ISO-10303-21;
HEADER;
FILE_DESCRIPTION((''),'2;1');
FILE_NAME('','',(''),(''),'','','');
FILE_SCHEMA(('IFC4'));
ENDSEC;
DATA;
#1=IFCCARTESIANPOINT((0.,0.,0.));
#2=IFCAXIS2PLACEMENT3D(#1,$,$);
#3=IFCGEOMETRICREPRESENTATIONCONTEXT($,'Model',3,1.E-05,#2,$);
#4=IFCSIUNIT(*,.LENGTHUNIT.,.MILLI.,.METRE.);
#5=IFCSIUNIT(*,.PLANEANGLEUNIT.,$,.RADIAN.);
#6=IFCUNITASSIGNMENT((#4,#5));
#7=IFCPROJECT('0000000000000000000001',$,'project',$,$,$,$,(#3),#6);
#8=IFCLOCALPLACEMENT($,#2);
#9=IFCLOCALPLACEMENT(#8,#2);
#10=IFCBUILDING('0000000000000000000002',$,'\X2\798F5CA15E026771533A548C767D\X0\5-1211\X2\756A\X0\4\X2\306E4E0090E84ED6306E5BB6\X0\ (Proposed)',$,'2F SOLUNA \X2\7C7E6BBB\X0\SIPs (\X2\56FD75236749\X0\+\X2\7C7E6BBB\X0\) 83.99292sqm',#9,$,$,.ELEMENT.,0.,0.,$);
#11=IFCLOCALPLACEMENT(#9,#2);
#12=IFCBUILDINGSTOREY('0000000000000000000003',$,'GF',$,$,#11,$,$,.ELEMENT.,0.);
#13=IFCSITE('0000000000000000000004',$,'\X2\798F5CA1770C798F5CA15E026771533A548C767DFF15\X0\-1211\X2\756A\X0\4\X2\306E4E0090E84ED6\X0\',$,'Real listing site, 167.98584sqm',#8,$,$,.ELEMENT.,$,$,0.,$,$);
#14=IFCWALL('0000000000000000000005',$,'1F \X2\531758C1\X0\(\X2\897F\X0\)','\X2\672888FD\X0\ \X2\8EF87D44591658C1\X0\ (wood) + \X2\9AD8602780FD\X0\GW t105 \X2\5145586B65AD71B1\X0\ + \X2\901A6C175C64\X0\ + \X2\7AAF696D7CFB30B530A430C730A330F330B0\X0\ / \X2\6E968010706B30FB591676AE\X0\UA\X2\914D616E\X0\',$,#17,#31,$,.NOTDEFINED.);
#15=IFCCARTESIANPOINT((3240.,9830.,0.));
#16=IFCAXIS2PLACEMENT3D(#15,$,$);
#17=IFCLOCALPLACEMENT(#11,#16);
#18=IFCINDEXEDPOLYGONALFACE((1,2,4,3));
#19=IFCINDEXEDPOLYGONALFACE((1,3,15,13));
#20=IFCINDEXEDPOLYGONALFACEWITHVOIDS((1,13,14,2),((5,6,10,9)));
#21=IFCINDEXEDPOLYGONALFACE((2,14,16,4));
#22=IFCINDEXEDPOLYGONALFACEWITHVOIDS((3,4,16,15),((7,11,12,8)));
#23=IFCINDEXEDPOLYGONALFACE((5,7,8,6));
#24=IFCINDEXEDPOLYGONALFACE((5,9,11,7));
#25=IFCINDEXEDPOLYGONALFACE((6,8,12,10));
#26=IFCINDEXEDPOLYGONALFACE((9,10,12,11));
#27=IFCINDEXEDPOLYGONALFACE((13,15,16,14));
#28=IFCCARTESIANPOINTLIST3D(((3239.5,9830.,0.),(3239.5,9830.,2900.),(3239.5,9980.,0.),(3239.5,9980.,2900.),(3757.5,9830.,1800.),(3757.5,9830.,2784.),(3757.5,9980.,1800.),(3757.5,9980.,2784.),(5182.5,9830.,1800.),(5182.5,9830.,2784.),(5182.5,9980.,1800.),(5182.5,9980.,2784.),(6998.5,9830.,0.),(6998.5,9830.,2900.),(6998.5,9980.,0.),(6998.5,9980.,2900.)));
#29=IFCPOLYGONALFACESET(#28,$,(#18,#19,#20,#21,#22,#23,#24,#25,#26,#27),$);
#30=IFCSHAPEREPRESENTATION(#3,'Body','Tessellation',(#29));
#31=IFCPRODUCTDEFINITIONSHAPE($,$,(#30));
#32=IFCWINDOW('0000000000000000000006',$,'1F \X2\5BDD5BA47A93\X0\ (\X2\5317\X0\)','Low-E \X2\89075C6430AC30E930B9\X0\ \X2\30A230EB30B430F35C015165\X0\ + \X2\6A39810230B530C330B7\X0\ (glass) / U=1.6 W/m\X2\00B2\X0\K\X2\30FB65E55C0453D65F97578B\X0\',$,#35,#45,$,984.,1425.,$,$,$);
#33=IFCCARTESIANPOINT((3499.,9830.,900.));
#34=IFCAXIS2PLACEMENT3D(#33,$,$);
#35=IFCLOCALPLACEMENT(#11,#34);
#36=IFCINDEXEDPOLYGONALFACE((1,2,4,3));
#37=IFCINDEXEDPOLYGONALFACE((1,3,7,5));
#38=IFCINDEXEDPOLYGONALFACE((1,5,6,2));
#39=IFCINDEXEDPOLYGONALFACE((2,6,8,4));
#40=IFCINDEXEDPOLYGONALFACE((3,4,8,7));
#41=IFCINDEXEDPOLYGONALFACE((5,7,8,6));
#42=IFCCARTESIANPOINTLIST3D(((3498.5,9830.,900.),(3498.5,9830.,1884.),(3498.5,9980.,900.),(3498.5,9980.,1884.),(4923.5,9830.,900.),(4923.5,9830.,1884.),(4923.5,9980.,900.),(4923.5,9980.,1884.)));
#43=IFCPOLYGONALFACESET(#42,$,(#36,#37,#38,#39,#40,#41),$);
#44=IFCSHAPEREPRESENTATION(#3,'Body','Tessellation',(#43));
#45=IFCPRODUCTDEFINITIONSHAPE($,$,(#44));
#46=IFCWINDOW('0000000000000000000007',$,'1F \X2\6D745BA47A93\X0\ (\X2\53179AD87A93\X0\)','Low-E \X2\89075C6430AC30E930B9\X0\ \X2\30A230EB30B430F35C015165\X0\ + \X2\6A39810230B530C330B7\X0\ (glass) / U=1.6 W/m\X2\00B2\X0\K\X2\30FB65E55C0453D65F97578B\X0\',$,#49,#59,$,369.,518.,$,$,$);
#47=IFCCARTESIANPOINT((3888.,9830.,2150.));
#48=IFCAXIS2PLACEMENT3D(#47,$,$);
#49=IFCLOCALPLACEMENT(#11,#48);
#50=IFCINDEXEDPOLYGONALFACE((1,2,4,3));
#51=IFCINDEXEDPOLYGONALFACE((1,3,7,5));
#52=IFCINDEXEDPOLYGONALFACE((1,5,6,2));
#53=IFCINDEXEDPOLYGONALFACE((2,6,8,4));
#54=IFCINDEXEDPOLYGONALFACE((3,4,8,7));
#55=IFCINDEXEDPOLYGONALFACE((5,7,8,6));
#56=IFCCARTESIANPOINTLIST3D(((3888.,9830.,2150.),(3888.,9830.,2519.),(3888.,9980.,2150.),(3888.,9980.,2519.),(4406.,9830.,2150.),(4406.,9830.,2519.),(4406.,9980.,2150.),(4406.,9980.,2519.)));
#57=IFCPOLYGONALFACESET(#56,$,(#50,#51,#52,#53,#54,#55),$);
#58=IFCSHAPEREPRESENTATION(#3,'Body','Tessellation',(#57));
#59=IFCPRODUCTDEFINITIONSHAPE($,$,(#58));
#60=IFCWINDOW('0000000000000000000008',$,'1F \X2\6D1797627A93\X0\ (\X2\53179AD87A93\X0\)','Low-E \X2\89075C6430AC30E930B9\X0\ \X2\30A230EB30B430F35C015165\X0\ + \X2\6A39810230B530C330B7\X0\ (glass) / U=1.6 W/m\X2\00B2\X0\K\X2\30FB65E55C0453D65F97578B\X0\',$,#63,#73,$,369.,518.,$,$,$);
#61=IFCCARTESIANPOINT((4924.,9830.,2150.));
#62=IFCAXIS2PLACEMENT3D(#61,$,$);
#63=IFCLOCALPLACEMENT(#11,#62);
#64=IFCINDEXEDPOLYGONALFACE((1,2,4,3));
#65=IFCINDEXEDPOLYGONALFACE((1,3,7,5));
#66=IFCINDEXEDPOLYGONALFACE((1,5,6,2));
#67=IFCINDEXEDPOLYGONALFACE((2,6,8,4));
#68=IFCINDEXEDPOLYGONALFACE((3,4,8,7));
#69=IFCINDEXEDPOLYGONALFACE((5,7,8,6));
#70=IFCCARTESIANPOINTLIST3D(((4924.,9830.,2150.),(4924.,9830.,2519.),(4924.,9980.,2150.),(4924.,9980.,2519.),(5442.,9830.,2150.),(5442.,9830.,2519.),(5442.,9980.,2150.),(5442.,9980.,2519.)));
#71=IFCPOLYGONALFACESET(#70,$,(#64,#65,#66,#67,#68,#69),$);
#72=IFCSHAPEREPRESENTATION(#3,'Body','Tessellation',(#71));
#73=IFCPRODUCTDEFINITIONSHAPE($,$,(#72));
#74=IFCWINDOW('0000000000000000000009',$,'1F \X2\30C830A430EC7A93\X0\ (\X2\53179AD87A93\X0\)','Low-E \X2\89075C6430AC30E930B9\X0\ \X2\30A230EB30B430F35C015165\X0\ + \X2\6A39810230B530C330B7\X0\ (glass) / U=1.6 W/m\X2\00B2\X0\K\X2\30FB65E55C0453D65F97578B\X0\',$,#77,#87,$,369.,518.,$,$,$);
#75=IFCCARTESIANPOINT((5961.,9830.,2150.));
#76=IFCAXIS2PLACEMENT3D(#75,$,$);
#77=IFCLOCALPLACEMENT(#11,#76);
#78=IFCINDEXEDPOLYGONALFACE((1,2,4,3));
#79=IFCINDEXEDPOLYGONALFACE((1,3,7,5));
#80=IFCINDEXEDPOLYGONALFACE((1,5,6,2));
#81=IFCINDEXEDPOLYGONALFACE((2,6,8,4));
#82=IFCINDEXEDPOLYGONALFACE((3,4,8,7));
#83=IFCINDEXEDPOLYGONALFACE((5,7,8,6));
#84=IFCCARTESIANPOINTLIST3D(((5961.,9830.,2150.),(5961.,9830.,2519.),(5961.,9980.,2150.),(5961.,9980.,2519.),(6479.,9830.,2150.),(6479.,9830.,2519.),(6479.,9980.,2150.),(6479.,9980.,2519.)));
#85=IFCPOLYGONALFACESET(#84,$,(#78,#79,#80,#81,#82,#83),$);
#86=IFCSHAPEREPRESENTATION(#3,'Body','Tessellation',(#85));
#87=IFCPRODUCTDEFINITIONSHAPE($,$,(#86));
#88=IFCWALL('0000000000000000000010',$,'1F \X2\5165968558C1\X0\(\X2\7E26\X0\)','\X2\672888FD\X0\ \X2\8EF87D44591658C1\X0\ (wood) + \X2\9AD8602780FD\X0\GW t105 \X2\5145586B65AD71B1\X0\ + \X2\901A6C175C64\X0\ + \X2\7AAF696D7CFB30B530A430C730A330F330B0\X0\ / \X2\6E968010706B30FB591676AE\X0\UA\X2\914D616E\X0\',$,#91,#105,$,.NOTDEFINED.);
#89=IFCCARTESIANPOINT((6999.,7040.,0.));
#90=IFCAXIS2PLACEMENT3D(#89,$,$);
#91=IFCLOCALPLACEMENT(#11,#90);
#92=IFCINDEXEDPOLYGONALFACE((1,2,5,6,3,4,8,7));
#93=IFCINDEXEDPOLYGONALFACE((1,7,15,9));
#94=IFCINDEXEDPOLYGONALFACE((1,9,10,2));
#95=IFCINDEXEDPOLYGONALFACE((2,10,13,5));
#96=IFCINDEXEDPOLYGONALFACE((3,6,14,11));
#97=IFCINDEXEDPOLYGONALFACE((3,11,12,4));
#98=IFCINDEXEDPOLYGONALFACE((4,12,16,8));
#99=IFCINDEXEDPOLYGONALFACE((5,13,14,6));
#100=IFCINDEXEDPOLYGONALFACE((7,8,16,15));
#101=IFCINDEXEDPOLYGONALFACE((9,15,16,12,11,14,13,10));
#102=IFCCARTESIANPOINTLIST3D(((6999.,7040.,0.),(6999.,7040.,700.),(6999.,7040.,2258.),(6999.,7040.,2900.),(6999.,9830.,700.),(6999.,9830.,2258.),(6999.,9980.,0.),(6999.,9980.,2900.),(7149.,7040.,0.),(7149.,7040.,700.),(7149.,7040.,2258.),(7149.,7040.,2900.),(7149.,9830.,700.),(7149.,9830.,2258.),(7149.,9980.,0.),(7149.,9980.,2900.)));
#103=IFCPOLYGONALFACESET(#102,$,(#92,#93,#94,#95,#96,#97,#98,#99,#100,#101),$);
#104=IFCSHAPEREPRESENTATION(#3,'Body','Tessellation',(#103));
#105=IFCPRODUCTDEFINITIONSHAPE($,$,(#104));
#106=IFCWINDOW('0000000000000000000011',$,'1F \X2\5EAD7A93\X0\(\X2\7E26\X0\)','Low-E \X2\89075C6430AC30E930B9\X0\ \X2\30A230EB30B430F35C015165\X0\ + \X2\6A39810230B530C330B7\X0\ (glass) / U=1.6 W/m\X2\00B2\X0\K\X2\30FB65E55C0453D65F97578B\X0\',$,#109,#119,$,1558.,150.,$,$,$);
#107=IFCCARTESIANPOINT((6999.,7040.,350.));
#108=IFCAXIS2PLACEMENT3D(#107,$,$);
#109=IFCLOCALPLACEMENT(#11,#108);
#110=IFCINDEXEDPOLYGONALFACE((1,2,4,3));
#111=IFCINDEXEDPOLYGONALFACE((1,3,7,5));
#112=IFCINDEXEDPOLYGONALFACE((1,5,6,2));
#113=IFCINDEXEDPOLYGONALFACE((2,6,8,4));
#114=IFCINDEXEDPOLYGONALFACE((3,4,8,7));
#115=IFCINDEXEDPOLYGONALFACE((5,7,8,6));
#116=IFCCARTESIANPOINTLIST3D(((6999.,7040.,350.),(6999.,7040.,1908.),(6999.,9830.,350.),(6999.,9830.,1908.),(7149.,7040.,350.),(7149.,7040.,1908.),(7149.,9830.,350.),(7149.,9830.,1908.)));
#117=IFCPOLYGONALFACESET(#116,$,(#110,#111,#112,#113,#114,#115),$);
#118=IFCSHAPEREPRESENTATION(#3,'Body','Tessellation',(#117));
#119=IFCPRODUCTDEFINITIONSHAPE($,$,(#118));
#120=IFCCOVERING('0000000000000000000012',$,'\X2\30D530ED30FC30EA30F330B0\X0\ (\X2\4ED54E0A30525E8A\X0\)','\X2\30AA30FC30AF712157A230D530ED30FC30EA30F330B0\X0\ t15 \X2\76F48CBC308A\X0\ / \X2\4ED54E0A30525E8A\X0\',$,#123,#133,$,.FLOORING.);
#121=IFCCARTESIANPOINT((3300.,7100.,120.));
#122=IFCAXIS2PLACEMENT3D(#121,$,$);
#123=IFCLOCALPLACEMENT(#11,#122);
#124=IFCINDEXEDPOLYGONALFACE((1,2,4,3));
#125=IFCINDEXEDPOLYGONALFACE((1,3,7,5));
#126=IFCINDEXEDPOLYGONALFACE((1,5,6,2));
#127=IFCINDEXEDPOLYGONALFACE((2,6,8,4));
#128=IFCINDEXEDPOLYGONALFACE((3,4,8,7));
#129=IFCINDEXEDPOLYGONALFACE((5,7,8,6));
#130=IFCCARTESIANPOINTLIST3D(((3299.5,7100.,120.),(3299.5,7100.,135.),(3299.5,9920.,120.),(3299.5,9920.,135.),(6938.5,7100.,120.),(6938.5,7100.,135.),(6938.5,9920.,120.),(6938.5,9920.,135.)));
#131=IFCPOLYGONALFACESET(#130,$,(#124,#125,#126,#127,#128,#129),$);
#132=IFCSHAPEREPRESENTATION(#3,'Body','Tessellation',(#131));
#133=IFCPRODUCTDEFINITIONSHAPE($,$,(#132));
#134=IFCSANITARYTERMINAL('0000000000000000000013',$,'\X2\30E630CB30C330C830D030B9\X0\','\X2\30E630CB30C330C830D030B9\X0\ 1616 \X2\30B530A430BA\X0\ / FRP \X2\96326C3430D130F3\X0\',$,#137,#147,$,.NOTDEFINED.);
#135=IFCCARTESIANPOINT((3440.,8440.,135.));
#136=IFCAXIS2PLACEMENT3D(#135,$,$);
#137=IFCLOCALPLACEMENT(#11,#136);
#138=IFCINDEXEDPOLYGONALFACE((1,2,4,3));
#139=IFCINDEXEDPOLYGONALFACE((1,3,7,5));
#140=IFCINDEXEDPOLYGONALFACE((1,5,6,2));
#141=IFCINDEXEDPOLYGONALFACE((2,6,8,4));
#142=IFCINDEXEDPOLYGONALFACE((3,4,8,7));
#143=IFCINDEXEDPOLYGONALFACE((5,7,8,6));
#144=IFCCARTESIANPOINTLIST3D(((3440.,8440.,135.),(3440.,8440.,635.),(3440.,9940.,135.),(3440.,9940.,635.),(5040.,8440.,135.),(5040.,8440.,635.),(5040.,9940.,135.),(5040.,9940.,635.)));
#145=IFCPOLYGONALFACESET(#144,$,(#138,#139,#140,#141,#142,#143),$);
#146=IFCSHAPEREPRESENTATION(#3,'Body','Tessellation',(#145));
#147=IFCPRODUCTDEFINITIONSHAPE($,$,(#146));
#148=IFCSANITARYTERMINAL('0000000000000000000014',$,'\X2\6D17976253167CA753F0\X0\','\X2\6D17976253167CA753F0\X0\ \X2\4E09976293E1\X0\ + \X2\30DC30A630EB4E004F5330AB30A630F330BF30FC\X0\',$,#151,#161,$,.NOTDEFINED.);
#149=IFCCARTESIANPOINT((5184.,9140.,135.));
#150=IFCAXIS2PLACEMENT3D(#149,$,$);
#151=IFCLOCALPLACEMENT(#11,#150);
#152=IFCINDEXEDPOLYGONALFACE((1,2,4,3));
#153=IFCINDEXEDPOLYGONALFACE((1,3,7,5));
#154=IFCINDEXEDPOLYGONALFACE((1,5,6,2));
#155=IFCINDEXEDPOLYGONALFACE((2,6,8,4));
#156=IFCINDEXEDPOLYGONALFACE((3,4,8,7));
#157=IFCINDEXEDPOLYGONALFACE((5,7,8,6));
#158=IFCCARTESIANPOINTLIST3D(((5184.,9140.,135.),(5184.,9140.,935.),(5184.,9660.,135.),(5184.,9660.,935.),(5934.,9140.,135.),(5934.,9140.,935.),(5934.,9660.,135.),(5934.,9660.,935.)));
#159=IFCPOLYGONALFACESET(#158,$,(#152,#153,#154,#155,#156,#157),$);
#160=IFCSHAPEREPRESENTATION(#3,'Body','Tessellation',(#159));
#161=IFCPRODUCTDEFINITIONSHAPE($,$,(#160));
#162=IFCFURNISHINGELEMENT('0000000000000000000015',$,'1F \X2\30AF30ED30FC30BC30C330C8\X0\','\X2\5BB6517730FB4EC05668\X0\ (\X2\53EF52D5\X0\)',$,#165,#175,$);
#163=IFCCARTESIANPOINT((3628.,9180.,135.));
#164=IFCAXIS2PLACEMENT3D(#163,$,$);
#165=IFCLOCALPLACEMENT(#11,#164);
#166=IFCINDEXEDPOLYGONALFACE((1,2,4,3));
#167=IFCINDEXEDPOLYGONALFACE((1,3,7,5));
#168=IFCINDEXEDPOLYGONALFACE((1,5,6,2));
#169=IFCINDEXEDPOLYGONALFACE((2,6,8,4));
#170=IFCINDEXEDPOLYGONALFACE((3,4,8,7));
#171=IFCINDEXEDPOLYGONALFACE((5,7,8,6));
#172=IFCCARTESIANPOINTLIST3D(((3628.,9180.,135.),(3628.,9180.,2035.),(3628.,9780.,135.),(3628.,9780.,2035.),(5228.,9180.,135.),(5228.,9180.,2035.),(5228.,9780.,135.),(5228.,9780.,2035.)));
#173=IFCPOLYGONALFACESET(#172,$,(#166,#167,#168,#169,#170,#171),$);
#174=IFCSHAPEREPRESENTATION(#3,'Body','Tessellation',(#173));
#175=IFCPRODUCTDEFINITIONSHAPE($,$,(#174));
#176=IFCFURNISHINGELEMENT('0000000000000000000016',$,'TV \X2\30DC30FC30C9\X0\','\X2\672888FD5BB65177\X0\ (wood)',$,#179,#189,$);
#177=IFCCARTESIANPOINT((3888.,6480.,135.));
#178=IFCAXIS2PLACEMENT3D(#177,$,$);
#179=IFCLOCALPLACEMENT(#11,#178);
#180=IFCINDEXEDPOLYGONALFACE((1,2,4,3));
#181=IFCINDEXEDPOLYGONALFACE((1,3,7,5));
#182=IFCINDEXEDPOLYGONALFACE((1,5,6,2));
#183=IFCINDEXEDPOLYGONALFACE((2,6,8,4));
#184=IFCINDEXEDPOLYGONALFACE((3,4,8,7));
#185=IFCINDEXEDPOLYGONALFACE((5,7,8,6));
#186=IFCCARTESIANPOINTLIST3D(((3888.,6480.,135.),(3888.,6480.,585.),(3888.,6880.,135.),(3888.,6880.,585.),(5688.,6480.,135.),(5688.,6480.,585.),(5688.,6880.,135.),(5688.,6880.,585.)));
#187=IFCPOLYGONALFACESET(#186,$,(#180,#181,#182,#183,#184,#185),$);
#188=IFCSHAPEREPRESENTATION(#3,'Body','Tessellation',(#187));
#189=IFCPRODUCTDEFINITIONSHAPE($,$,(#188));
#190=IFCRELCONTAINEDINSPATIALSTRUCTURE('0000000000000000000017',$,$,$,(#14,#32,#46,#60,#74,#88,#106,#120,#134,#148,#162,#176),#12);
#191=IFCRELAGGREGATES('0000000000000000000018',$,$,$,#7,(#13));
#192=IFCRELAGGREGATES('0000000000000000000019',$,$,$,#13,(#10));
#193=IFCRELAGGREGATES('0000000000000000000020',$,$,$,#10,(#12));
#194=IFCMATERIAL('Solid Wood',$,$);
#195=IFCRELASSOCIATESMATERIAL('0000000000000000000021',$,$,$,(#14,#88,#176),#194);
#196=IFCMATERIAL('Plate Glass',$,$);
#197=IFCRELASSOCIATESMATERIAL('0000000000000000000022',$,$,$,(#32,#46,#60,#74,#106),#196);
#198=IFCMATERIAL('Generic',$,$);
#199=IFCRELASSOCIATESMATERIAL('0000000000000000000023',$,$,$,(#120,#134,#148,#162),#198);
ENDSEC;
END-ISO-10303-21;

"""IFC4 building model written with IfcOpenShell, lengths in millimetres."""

from ifc_helpers import new_model, si_unit, frame, frame_2d, origin, place, context, project, spatial, rectangle, extrude, material, element, fill, save


model = new_model("IFC4")

# Units and contexts
model_context = context("Model", 3, precision=1e-05, world=origin())
ifc_project = project(units=[si_unit("LENGTHUNIT", "METRE", prefix="MILLI"), si_unit("PLANEANGLEUNIT", "RADIAN")], contexts=[model_context])

# Site, building, storey
site_placement = place(None, origin())
site = spatial("IfcSite", under=ifc_project, at=site_placement, Name="福岡県福岡市東区和白５-1211番4の一部他", ObjectType="Real listing site, 167.98584sqm", CompositionType="ELEMENT", RefElevation=0.0)
building_placement = place(site_placement, origin())
building = spatial("IfcBuilding", under=site, at=building_placement, Name="福岡市東区和白5-1211番4の一部他の家 (Proposed)", ObjectType="2F SOLUNA 籾殻SIPs (国産杉+籾殻) 83.99292sqm", CompositionType="ELEMENT", ElevationOfRefHeight=0.0, ElevationOfTerrain=0.0)
storey_placement = place(building_placement, origin())
storey = spatial("IfcBuildingStorey", under=building, at=storey_placement, Name="GF", CompositionType="ELEMENT", Elevation=0.0)

# Shared definitions
ifc_material_1 = material(Name="Solid Wood")

# Wall, openings, windows
wall_1_placement = place(storey_placement, frame((3240.0, 9830.0, 0.0)))
wall_1 = element("IfcWall", 1, at=wall_1_placement, inside=storey, material=ifc_material_1, Name="1F 北壁(西)", Description="木製 軸組外壁 (wood) + 高性能GW t105 充填断熱 + 通気層 + 窯業系サイディング / 準耐火・外皮UA配慮", PredefinedType="NOTDEFINED", context=model_context, shape_type="SweptSolid", body=[
    extrude(rectangle(XDim=3759.0, YDim=150.0, at=frame_2d((1879.0, 75.0))), frame((3240.0, 9830.0, 0.0)), (0.0, 0.0, 1.0), 2900.0),
])
opening_1_placement = place(storey_placement, frame((3499.0, 9830.0, 900.0)))
opening_1 = element("IfcOpeningElement", 2, at=opening_1_placement, cuts=wall_1, PredefinedType="NOTDEFINED", context=model_context, shape_type="SweptSolid", body=[
    extrude(rectangle(XDim=1425.0, YDim=150.0, at=frame_2d((712.0, 75.0))), frame((3499.0, 9830.0, 900.0)), (0.0, 0.0, 1.0), 984.0),
])
opening_2_placement = place(storey_placement, frame((3888.0, 9830.0, 2150.0)))
opening_2 = element("IfcOpeningElement", 3, at=opening_2_placement, cuts=wall_1, PredefinedType="NOTDEFINED", context=model_context, shape_type="SweptSolid", body=[
    extrude(rectangle(XDim=518.0, YDim=150.0, at=frame_2d((259.0, 75.0))), frame((3888.0, 9830.0, 2150.0)), (0.0, 0.0, 1.0), 369.0),
])
opening_3_placement = place(storey_placement, frame((4924.0, 9830.0, 2150.0)))
opening_3 = element("IfcOpeningElement", 4, at=opening_3_placement, cuts=wall_1, PredefinedType="NOTDEFINED", context=model_context, shape_type="SweptSolid", body=[
    extrude(rectangle(XDim=518.0, YDim=150.0, at=frame_2d((259.0, 75.0))), frame((4924.0, 9830.0, 2150.0)), (0.0, 0.0, 1.0), 369.0),
])
opening_4_placement = place(storey_placement, frame((5961.0, 9830.0, 2150.0)))
opening_4 = element("IfcOpeningElement", 5, at=opening_4_placement, cuts=wall_1, PredefinedType="NOTDEFINED", context=model_context, shape_type="SweptSolid", body=[
    extrude(rectangle(XDim=518.0, YDim=150.0, at=frame_2d((259.0, 75.0))), frame((5961.0, 9830.0, 2150.0)), (0.0, 0.0, 1.0), 369.0),
])
ifc_material_2 = material(Name="Plate Glass")
window_1_placement = place(storey_placement, frame((3499.0, 9830.0, 900.0)))
window_1 = element("IfcWindow", 6, at=window_1_placement, inside=storey, material=ifc_material_2, Name="1F 寝室窓 (北)", Description="Low-E 複層ガラス アルゴン封入 + 樹脂サッシ (glass) / U=1.6 W/m²K・日射取得型", OverallHeight=984.0, OverallWidth=1425.0, context=model_context, shape_type="SweptSolid", body=[
    extrude(rectangle(XDim=1425.0, YDim=150.0, at=frame_2d((712.0, 75.0))), frame((3499.0, 9830.0, 900.0)), (0.0, 0.0, 1.0), 984.0),
])
fill(opening_1, window_1)
window_2_placement = place(storey_placement, frame((3888.0, 9830.0, 2150.0)))
window_2 = element("IfcWindow", 7, at=window_2_placement, inside=storey, material=ifc_material_2, Name="1F 浴室窓 (北高窓)", Description="Low-E 複層ガラス アルゴン封入 + 樹脂サッシ (glass) / U=1.6 W/m²K・日射取得型", OverallHeight=369.0, OverallWidth=518.0, context=model_context, shape_type="SweptSolid", body=[
    extrude(rectangle(XDim=518.0, YDim=150.0, at=frame_2d((259.0, 75.0))), frame((3888.0, 9830.0, 2150.0)), (0.0, 0.0, 1.0), 369.0),
])
fill(opening_2, window_2)
window_3_placement = place(storey_placement, frame((4924.0, 9830.0, 2150.0)))
window_3 = element("IfcWindow", 8, at=window_3_placement, inside=storey, material=ifc_material_2, Name="1F 洗面窓 (北高窓)", Description="Low-E 複層ガラス アルゴン封入 + 樹脂サッシ (glass) / U=1.6 W/m²K・日射取得型", OverallHeight=369.0, OverallWidth=518.0, context=model_context, shape_type="SweptSolid", body=[
    extrude(rectangle(XDim=518.0, YDim=150.0, at=frame_2d((259.0, 75.0))), frame((4924.0, 9830.0, 2150.0)), (0.0, 0.0, 1.0), 369.0),
])
fill(opening_3, window_3)
window_4_placement = place(storey_placement, frame((5961.0, 9830.0, 2150.0)))
window_4 = element("IfcWindow", 9, at=window_4_placement, inside=storey, material=ifc_material_2, Name="1F トイレ窓 (北高窓)", Description="Low-E 複層ガラス アルゴン封入 + 樹脂サッシ (glass) / U=1.6 W/m²K・日射取得型", OverallHeight=369.0, OverallWidth=518.0, context=model_context, shape_type="SweptSolid", body=[
    extrude(rectangle(XDim=518.0, YDim=150.0, at=frame_2d((259.0, 75.0))), frame((5961.0, 9830.0, 2150.0)), (0.0, 0.0, 1.0), 369.0),
])
fill(opening_4, window_4)

# Wall, opening, window
wall_2_placement = place(storey_placement, frame((6999.0, 7040.0, 0.0)))
wall_2 = element("IfcWall", 10, at=wall_2_placement, inside=storey, material=ifc_material_1, Name="1F 入隅壁(縦)", Description="木製 軸組外壁 (wood) + 高性能GW t105 充填断熱 + 通気層 + 窯業系サイディング / 準耐火・外皮UA配慮", PredefinedType="NOTDEFINED", context=model_context, shape_type="SweptSolid", body=[
    extrude(rectangle(XDim=150.0, YDim=2940.0, at=frame_2d((75.0, 1470.0))), frame((6999.0, 7040.0, 0.0)), (0.0, 0.0, 1.0), 2900.0),
])
opening_5_placement = place(storey_placement, frame((6999.0, 7040.0, 350.0)))
opening_5 = element("IfcOpeningElement", 11, at=opening_5_placement, cuts=wall_2, PredefinedType="NOTDEFINED", context=model_context, shape_type="SweptSolid", body=[
    extrude(rectangle(XDim=150.0, YDim=2790.0, at=frame_2d((75.0, 1395.0))), frame((6999.0, 7040.0, 350.0)), (0.0, 0.0, 1.0), 1558.0),
])
window_5_placement = place(storey_placement, frame((6999.0, 7040.0, 350.0)))
window_5 = element("IfcWindow", 12, at=window_5_placement, inside=storey, material=ifc_material_2, Name="1F 庭窓(縦)", Description="Low-E 複層ガラス アルゴン封入 + 樹脂サッシ (glass) / U=1.6 W/m²K・日射取得型", OverallHeight=1558.0, OverallWidth=150.0, context=model_context, shape_type="SweptSolid", body=[
    extrude(rectangle(XDim=150.0, YDim=2790.0, at=frame_2d((75.0, 1395.0))), frame((6999.0, 7040.0, 350.0)), (0.0, 0.0, 1.0), 1558.0),
])
fill(opening_5, window_5)

# Covering
ifc_material_3 = material(Name="Generic")
covering_placement = place(storey_placement, frame((3300.0, 7100.0, 120.0)))
element("IfcCovering", 13, at=covering_placement, inside=storey, material=ifc_material_3, Name="フローリング (仕上げ床)", Description="オーク無垢フローリング t15 直貼り / 仕上げ床", PredefinedType="FLOORING", context=model_context, shape_type="SweptSolid", body=[
    extrude(rectangle(XDim=3639.0, YDim=2820.0, at=frame_2d((1819.0, 1410.0))), frame((3300.0, 7100.0, 120.0)), (0.0, 0.0, 1.0), 15.0),
])

# Sanitary terminals
sanitary_terminal_1_placement = place(storey_placement, frame((3440.0, 8440.0, 135.0)))
element("IfcSanitaryTerminal", 14, at=sanitary_terminal_1_placement, inside=storey, material=ifc_material_3, Name="ユニットバス", Description="ユニットバス 1616 サイズ / FRP 防水パン", PredefinedType="NOTDEFINED", context=model_context, shape_type="SweptSolid", body=[
    extrude(rectangle(XDim=1600.0, YDim=1500.0, at=frame_2d((800.0, 750.0))), frame((3440.0, 8440.0, 135.0)), (0.0, 0.0, 1.0), 500.0),
])
sanitary_terminal_2_placement = place(storey_placement, frame((5184.0, 9140.0, 135.0)))
element("IfcSanitaryTerminal", 15, at=sanitary_terminal_2_placement, inside=storey, material=ifc_material_3, Name="洗面化粧台", Description="洗面化粧台 三面鏡 + ボウル一体カウンター", PredefinedType="NOTDEFINED", context=model_context, shape_type="SweptSolid", body=[
    extrude(rectangle(XDim=750.0, YDim=520.0, at=frame_2d((375.0, 260.0))), frame((5184.0, 9140.0, 135.0)), (0.0, 0.0, 1.0), 800.0),
])

# Furnishing elements
furnishing_1_placement = place(storey_placement, frame((3628.0, 9180.0, 135.0)))
element("IfcFurnishingElement", 16, at=furnishing_1_placement, inside=storey, material=ifc_material_3, Name="1F クローゼット", Description="家具・什器 (可動)", context=model_context, shape_type="SweptSolid", body=[
    extrude(rectangle(XDim=1600.0, YDim=600.0, at=frame_2d((800.0, 300.0))), frame((3628.0, 9180.0, 135.0)), (0.0, 0.0, 1.0), 1900.0),
])
furnishing_2_placement = place(storey_placement, frame((3888.0, 6480.0, 135.0)))
element("IfcFurnishingElement", 17, at=furnishing_2_placement, inside=storey, material=ifc_material_1, Name="TV ボード", Description="木製家具 (wood)", context=model_context, shape_type="SweptSolid", body=[
    extrude(rectangle(XDim=1800.0, YDim=400.0, at=frame_2d((900.0, 200.0))), frame((3888.0, 6480.0, 135.0)), (0.0, 0.0, 1.0), 450.0),
])

save(model, "model.ifc")
